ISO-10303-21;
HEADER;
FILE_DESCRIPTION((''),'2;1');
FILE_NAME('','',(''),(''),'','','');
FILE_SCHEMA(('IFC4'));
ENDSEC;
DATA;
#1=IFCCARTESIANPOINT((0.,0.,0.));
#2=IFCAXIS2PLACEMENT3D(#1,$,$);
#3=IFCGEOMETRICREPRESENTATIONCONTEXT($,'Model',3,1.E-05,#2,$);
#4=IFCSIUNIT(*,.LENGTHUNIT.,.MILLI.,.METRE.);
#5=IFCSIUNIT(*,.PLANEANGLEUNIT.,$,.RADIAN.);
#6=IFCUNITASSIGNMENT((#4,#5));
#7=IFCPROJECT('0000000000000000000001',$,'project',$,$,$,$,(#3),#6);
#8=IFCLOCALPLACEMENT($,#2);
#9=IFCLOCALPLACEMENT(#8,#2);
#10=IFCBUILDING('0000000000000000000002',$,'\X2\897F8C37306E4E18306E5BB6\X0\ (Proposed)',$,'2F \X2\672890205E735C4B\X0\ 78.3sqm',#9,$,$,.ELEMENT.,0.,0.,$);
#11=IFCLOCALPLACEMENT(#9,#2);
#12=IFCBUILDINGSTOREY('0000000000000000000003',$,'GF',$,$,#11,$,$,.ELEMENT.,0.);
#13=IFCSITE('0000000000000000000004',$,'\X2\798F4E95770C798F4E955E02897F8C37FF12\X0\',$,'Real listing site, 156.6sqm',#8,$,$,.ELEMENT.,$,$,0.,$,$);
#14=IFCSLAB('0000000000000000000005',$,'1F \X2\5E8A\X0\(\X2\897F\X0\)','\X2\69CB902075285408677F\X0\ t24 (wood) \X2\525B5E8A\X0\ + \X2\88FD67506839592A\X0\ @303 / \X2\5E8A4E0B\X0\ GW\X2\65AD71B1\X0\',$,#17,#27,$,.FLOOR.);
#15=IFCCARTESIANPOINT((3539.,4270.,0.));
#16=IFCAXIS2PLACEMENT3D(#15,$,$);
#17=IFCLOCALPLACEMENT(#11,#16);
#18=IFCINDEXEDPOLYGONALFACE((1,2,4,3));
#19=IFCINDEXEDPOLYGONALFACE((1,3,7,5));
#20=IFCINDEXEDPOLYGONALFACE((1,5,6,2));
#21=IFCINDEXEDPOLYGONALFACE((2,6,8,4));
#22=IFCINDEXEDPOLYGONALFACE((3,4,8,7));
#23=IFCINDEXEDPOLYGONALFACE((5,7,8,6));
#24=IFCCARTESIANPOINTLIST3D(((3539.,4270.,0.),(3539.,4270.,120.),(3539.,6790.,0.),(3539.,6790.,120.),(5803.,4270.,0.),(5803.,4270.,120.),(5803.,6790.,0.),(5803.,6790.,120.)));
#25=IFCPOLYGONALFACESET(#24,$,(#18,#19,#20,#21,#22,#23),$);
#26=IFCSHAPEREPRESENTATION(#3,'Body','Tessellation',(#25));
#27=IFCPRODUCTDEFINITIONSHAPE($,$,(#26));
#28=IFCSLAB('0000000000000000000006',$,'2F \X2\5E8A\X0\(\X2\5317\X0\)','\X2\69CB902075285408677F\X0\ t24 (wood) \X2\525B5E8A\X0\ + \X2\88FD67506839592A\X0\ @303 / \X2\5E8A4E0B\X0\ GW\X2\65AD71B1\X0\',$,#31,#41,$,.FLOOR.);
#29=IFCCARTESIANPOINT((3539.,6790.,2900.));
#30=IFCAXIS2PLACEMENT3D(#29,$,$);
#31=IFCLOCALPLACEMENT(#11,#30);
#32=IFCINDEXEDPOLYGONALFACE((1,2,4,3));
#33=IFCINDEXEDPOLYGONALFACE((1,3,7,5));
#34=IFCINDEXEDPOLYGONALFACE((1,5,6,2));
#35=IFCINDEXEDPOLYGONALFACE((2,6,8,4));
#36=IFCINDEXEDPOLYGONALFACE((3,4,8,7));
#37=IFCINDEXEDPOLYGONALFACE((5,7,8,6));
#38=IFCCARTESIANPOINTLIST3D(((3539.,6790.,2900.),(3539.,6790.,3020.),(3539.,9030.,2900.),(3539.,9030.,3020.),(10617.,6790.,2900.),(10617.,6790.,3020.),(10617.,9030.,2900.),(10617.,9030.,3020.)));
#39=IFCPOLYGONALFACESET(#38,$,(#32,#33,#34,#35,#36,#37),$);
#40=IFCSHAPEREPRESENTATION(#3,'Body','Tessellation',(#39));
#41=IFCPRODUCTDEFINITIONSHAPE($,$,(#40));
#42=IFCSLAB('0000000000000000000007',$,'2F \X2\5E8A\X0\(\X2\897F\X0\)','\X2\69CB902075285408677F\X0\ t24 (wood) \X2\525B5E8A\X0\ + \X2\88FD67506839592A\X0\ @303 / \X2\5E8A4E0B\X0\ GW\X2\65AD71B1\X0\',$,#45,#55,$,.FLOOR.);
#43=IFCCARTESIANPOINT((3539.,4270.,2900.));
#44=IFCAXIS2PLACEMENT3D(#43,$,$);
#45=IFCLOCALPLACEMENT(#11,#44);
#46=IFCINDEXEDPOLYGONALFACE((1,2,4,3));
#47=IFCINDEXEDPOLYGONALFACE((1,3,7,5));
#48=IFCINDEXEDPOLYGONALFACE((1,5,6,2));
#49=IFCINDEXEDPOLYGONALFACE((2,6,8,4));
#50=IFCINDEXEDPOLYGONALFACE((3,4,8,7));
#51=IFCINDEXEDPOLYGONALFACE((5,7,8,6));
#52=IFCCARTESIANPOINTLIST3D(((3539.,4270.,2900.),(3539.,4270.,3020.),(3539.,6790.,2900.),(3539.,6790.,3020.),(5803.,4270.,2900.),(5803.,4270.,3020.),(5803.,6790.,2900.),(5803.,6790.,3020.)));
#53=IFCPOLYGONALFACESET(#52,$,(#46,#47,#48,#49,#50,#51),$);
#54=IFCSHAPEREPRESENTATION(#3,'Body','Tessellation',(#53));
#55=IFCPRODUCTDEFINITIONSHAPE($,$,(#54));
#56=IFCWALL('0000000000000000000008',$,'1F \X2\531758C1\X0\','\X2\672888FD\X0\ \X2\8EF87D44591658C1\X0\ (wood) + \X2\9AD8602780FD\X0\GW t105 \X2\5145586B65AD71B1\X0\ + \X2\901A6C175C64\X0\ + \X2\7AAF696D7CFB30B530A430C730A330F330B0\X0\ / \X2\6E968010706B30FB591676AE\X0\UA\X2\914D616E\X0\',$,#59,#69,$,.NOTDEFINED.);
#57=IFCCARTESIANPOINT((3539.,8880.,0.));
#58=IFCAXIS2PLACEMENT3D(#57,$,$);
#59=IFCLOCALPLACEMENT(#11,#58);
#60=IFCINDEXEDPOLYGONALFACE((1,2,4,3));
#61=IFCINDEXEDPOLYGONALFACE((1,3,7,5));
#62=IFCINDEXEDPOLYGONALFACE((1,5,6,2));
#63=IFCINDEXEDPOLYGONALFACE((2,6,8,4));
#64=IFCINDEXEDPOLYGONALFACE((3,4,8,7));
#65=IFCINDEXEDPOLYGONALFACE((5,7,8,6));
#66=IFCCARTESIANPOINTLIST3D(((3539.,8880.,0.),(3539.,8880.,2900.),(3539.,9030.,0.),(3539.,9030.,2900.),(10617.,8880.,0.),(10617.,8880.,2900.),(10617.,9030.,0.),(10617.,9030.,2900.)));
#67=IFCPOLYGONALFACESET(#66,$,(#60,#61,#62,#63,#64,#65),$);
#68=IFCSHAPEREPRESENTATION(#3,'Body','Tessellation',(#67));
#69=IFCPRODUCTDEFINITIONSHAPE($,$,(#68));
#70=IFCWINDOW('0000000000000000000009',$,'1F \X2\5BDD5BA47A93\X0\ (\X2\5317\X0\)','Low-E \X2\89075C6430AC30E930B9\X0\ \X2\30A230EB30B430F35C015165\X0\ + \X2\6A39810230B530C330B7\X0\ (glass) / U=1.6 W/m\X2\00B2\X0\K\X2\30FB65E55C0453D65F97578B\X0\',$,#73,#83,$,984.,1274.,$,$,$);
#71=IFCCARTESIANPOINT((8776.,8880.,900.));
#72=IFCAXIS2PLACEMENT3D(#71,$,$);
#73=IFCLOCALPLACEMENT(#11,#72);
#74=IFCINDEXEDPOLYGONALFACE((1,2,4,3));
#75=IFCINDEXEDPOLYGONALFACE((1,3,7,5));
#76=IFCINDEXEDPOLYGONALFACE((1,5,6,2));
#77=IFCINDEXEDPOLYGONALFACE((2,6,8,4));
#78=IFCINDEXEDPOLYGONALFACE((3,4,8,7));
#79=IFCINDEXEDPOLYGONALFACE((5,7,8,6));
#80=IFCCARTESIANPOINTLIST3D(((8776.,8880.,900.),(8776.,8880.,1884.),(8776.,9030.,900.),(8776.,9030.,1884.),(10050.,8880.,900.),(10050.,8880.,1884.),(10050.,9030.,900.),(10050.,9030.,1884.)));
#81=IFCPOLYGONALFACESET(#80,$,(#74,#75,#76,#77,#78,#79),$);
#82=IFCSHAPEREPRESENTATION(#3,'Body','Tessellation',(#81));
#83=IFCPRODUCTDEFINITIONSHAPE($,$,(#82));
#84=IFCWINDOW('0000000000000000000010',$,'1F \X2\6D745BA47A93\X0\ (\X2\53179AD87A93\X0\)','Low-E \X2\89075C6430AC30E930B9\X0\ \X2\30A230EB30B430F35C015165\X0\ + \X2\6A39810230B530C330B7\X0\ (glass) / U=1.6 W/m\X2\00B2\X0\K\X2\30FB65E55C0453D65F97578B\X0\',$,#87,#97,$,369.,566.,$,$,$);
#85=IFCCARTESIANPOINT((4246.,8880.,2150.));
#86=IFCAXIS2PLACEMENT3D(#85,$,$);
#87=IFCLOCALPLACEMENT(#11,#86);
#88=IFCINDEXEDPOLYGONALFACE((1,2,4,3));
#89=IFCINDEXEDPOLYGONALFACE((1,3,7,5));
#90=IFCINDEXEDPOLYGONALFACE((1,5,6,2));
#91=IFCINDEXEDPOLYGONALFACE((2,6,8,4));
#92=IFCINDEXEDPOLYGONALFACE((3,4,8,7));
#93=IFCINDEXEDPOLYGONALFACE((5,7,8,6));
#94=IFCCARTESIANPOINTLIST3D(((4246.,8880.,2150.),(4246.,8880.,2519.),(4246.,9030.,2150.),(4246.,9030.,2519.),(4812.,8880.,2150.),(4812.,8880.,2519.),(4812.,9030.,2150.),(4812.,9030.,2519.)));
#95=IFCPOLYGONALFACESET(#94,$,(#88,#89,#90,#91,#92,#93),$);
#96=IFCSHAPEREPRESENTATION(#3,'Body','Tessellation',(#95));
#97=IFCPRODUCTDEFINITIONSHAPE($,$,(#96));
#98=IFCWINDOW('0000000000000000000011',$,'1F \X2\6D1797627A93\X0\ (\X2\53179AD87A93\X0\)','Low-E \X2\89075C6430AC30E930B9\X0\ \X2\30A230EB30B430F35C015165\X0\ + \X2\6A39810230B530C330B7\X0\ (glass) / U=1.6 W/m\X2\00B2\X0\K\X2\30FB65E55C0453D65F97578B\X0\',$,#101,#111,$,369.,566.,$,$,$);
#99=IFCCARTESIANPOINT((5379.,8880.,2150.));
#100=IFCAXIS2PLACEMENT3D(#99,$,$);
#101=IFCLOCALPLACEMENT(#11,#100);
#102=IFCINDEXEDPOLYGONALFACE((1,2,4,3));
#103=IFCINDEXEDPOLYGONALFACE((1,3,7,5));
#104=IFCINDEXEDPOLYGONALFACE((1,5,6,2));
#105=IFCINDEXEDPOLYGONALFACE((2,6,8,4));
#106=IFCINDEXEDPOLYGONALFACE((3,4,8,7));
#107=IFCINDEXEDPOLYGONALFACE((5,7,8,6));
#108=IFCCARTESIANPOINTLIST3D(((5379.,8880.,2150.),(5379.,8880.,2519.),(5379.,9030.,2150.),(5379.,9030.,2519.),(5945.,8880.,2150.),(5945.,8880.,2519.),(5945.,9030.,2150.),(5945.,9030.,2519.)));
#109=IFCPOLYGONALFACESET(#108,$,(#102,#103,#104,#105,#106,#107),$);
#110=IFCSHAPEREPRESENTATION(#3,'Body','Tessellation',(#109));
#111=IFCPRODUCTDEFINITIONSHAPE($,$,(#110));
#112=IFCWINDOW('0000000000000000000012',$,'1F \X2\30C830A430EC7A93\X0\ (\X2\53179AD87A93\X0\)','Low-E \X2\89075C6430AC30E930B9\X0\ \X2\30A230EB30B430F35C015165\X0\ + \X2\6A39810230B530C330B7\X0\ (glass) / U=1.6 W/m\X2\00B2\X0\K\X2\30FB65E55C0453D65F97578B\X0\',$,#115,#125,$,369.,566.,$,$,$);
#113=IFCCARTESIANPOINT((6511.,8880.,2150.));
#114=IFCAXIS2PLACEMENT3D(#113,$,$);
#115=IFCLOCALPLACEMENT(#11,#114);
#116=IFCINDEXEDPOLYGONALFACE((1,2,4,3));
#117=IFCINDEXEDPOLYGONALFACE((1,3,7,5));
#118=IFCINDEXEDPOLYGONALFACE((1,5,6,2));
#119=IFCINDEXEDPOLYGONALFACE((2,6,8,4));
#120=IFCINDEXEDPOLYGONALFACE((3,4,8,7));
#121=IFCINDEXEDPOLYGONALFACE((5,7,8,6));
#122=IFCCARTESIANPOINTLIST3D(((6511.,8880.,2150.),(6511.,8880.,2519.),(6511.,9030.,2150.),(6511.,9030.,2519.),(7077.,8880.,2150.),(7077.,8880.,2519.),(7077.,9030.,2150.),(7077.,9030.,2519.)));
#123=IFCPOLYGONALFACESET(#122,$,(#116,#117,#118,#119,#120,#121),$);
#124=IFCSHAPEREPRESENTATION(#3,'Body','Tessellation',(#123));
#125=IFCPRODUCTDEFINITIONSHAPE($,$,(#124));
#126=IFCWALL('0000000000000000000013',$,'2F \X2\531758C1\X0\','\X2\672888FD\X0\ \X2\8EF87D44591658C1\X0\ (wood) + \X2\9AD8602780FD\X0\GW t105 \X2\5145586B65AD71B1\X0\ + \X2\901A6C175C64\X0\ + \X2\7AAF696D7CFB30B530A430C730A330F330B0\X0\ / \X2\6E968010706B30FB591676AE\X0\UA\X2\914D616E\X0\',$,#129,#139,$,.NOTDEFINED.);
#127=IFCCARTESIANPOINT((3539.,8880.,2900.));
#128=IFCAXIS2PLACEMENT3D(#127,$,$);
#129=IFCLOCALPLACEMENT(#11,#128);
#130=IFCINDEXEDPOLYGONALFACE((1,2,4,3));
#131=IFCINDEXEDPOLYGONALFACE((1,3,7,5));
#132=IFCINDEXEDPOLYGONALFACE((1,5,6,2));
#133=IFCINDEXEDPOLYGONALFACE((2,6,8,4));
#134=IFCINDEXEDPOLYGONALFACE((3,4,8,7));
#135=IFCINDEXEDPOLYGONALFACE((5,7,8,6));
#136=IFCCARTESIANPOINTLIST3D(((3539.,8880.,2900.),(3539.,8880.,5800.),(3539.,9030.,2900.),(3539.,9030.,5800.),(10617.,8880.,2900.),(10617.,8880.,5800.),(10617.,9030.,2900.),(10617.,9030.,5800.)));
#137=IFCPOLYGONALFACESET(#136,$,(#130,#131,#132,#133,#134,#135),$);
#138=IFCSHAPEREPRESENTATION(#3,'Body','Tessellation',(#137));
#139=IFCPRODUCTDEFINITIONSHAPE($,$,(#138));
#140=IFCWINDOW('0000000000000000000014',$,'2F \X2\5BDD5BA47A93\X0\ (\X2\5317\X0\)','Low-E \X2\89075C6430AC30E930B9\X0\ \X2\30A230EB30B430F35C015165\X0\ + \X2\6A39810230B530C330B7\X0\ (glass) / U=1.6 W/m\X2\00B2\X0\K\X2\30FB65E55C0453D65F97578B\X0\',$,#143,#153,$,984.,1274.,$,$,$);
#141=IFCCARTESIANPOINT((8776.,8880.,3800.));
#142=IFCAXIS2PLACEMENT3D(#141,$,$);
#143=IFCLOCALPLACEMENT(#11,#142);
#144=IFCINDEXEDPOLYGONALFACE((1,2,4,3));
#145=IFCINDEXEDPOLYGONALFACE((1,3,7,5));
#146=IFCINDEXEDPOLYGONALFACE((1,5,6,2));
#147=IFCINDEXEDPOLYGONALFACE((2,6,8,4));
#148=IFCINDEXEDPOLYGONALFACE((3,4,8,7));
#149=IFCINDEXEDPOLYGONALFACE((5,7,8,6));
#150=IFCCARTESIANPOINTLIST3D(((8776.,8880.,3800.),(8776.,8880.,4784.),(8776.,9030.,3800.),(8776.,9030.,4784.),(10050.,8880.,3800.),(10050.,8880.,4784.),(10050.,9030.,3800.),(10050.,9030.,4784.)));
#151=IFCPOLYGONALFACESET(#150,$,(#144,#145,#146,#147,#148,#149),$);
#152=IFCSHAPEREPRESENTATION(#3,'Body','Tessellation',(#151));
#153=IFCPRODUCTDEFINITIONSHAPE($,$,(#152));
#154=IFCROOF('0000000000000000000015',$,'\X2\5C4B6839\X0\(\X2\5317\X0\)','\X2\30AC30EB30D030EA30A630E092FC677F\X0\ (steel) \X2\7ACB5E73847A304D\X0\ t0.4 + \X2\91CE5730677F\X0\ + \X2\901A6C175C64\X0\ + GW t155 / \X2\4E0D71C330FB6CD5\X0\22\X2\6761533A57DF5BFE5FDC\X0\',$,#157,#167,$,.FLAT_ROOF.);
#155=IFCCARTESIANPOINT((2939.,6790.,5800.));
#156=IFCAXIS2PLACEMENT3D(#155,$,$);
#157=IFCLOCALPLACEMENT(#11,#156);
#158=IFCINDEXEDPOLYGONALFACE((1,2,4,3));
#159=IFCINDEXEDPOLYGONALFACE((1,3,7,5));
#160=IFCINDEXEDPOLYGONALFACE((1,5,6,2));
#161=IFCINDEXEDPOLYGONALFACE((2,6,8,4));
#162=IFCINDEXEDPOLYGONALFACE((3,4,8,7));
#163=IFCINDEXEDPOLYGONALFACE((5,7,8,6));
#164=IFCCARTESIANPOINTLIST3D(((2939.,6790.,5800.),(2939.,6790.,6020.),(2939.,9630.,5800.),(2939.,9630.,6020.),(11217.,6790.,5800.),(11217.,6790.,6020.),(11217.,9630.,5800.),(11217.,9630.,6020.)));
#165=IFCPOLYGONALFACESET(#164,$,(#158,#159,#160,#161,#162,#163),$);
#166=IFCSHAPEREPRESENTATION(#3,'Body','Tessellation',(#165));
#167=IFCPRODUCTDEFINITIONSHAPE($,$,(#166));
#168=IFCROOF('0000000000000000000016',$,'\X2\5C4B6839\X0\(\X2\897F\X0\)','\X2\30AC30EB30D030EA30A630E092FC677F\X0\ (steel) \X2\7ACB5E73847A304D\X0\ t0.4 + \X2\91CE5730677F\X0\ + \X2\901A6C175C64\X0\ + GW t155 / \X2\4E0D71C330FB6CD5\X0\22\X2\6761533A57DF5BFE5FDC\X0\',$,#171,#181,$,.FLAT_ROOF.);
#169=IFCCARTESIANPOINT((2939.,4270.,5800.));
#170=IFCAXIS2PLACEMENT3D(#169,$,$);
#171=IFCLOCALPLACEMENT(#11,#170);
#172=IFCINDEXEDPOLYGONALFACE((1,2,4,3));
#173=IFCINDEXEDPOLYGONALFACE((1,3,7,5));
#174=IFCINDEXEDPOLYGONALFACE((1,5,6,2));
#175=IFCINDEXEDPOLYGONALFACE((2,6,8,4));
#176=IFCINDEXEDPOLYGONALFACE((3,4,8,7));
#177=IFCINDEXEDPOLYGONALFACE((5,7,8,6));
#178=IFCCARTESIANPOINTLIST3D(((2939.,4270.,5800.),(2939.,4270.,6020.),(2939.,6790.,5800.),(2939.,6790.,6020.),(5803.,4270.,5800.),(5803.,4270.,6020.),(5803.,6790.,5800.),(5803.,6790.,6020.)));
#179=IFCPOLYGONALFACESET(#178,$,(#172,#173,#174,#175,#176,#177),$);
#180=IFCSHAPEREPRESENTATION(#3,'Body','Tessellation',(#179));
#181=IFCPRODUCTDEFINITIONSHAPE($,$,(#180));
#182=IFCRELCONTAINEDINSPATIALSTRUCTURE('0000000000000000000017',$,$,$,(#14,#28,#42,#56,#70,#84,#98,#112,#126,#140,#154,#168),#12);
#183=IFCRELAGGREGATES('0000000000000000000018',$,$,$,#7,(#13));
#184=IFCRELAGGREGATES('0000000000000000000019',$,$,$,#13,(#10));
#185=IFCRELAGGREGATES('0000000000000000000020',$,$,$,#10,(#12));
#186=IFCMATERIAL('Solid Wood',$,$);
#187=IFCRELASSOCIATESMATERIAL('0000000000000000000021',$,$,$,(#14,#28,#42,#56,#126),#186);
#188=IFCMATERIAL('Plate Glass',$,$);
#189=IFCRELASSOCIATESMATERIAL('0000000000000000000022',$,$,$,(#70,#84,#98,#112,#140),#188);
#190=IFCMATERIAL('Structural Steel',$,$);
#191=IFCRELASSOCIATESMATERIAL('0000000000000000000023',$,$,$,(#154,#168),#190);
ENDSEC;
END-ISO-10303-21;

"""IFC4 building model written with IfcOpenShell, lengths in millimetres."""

from ifc_helpers import new_model, si_unit, frame, frame_2d, origin, place, context, project, spatial, rectangle, extrude, material, element, fill, save


model = new_model("IFC4")

# Units and contexts
model_context = context("Model", 3, precision=1e-05, world=origin())
ifc_project = project(units=[si_unit("LENGTHUNIT", "METRE", prefix="MILLI"), si_unit("PLANEANGLEUNIT", "RADIAN")], contexts=[model_context])

# Site, building, storey
site_placement = place(None, origin())
site = spatial("IfcSite", under=ifc_project, at=site_placement, Name="福井県福井市西谷２", ObjectType="Real listing site, 156.6sqm", CompositionType="ELEMENT", RefElevation=0.0)
building_placement = place(site_placement, origin())
building = spatial("IfcBuilding", under=site, at=building_placement, Name="西谷の丘の家 (Proposed)", ObjectType="2F 木造平屋 78.3sqm", CompositionType="ELEMENT", ElevationOfRefHeight=0.0, ElevationOfTerrain=0.0)
storey_placement = place(building_placement, origin())
storey = spatial("IfcBuildingStorey", under=building, at=storey_placement, Name="GF", CompositionType="ELEMENT", Elevation=0.0)

# Slabs
ifc_material_1 = material(Name="Solid Wood")
slab_1_placement = place(storey_placement, frame((3539.0, 4270.0, 0.0)))
element("IfcSlab", 1, at=slab_1_placement, inside=storey, material=ifc_material_1, Name="1F 床(西)", Description="構造用合板 t24 (wood) 剛床 + 製材根太 @303 / 床下 GW断熱", PredefinedType="FLOOR", context=model_context, shape_type="SweptSolid", body=[
    extrude(rectangle(XDim=2264.0, YDim=2520.0, at=frame_2d((1132.0, 1260.0))), frame((3539.0, 4270.0, 0.0)), (0.0, 0.0, 1.0), 120.0),
])
slab_2_placement = place(storey_placement, frame((3539.0, 6790.0, 2900.0)))
element("IfcSlab", 2, at=slab_2_placement, inside=storey, material=ifc_material_1, Name="2F 床(北)", Description="構造用合板 t24 (wood) 剛床 + 製材根太 @303 / 床下 GW断熱", PredefinedType="FLOOR", context=model_context, shape_type="SweptSolid", body=[
    extrude(rectangle(XDim=7078.0, YDim=2240.0, at=frame_2d((3539.0, 1120.0))), frame((3539.0, 6790.0, 2900.0)), (0.0, 0.0, 1.0), 120.0),
])
slab_3_placement = place(storey_placement, frame((3539.0, 4270.0, 2900.0)))
element("IfcSlab", 3, at=slab_3_placement, inside=storey, material=ifc_material_1, Name="2F 床(西)", Description="構造用合板 t24 (wood) 剛床 + 製材根太 @303 / 床下 GW断熱", PredefinedType="FLOOR", context=model_context, shape_type="SweptSolid", body=[
    extrude(rectangle(XDim=2264.0, YDim=2520.0, at=frame_2d((1132.0, 1260.0))), frame((3539.0, 4270.0, 2900.0)), (0.0, 0.0, 1.0), 120.0),
])

# Wall, openings, windows
wall_1_placement = place(storey_placement, frame((3539.0, 8880.0, 0.0)))
wall_1 = element("IfcWall", 4, at=wall_1_placement, inside=storey, material=ifc_material_1, Name="1F 北壁", Description="木製 軸組外壁 (wood) + 高性能GW t105 充填断熱 + 通気層 + 窯業系サイディング / 準耐火・外皮UA配慮", PredefinedType="NOTDEFINED", context=model_context, shape_type="SweptSolid", body=[
    extrude(rectangle(XDim=7078.0, YDim=150.0, at=frame_2d((3539.0, 75.0))), frame((3539.0, 8880.0, 0.0)), (0.0, 0.0, 1.0), 2900.0),
])
opening_1_placement = place(storey_placement, frame((8776.0, 8880.0, 900.0)))
opening_1 = element("IfcOpeningElement", 5, at=opening_1_placement, cuts=wall_1, PredefinedType="NOTDEFINED", context=model_context, shape_type="SweptSolid", body=[
    extrude(rectangle(XDim=1274.0, YDim=150.0, at=frame_2d((637.0, 75.0))), frame((8776.0, 8880.0, 900.0)), (0.0, 0.0, 1.0), 984.0),
])
opening_2_placement = place(storey_placement, frame((4246.0, 8880.0, 2150.0)))
opening_2 = element("IfcOpeningElement", 6, at=opening_2_placement, cuts=wall_1, PredefinedType="NOTDEFINED", context=model_context, shape_type="SweptSolid", body=[
    extrude(rectangle(XDim=566.0, YDim=150.0, at=frame_2d((283.0, 75.0))), frame((4246.0, 8880.0, 2150.0)), (0.0, 0.0, 1.0), 369.0),
])
opening_3_placement = place(storey_placement, frame((5379.0, 8880.0, 2150.0)))
opening_3 = element("IfcOpeningElement", 7, at=opening_3_placement, cuts=wall_1, PredefinedType="NOTDEFINED", context=model_context, shape_type="SweptSolid", body=[
    extrude(rectangle(XDim=566.0, YDim=150.0, at=frame_2d((283.0, 75.0))), frame((5379.0, 8880.0, 2150.0)), (0.0, 0.0, 1.0), 369.0),
])
opening_4_placement = place(storey_placement, frame((6511.0, 8880.0, 2150.0)))
opening_4 = element("IfcOpeningElement", 8, at=opening_4_placement, cuts=wall_1, PredefinedType="NOTDEFINED", context=model_context, shape_type="SweptSolid", body=[
    extrude(rectangle(XDim=566.0, YDim=150.0, at=frame_2d((283.0, 75.0))), frame((6511.0, 8880.0, 2150.0)), (0.0, 0.0, 1.0), 369.0),
])
ifc_material_2 = material(Name="Plate Glass")
window_1_placement = place(storey_placement, frame((8776.0, 8880.0, 900.0)))
window_1 = element("IfcWindow", 9, at=window_1_placement, inside=storey, material=ifc_material_2, Name="1F 寝室窓 (北)", Description="Low-E 複層ガラス アルゴン封入 + 樹脂サッシ (glass) / U=1.6 W/m²K・日射取得型", OverallHeight=984.0, OverallWidth=1274.0, context=model_context, shape_type="SweptSolid", body=[
    extrude(rectangle(XDim=1274.0, YDim=150.0, at=frame_2d((637.0, 75.0))), frame((8776.0, 8880.0, 900.0)), (0.0, 0.0, 1.0), 984.0),
])
fill(opening_1, window_1)
window_2_placement = place(storey_placement, frame((4246.0, 8880.0, 2150.0)))
window_2 = element("IfcWindow", 10, at=window_2_placement, inside=storey, material=ifc_material_2, Name="1F 浴室窓 (北高窓)", Description="Low-E 複層ガラス アルゴン封入 + 樹脂サッシ (glass) / U=1.6 W/m²K・日射取得型", OverallHeight=369.0, OverallWidth=566.0, context=model_context, shape_type="SweptSolid", body=[
    extrude(rectangle(XDim=566.0, YDim=150.0, at=frame_2d((283.0, 75.0))), frame((4246.0, 8880.0, 2150.0)), (0.0, 0.0, 1.0), 369.0),
])
fill(opening_2, window_2)
window_3_placement = place(storey_placement, frame((5379.0, 8880.0, 2150.0)))
window_3 = element("IfcWindow", 11, at=window_3_placement, inside=storey, material=ifc_material_2, Name="1F 洗面窓 (北高窓)", Description="Low-E 複層ガラス アルゴン封入 + 樹脂サッシ (glass) / U=1.6 W/m²K・日射取得型", OverallHeight=369.0, OverallWidth=566.0, context=model_context, shape_type="SweptSolid", body=[
    extrude(rectangle(XDim=566.0, YDim=150.0, at=frame_2d((283.0, 75.0))), frame((5379.0, 8880.0, 2150.0)), (0.0, 0.0, 1.0), 369.0),
])
fill(opening_3, window_3)
window_4_placement = place(storey_placement, frame((6511.0, 8880.0, 2150.0)))
window_4 = element("IfcWindow", 12, at=window_4_placement, inside=storey, material=ifc_material_2, Name="1F トイレ窓 (北高窓)", Description="Low-E 複層ガラス アルゴン封入 + 樹脂サッシ (glass) / U=1.6 W/m²K・日射取得型", OverallHeight=369.0, OverallWidth=566.0, context=model_context, shape_type="SweptSolid", body=[
    extrude(rectangle(XDim=566.0, YDim=150.0, at=frame_2d((283.0, 75.0))), frame((6511.0, 8880.0, 2150.0)), (0.0, 0.0, 1.0), 369.0),
])
fill(opening_4, window_4)

# Wall, opening, window
wall_2_placement = place(storey_placement, frame((3539.0, 8880.0, 2900.0)))
wall_2 = element("IfcWall", 13, at=wall_2_placement, inside=storey, material=ifc_material_1, Name="2F 北壁", Description="木製 軸組外壁 (wood) + 高性能GW t105 充填断熱 + 通気層 + 窯業系サイディング / 準耐火・外皮UA配慮", PredefinedType="NOTDEFINED", context=model_context, shape_type="SweptSolid", body=[
    extrude(rectangle(XDim=7078.0, YDim=150.0, at=frame_2d((3539.0, 75.0))), frame((3539.0, 8880.0, 2900.0)), (0.0, 0.0, 1.0), 2900.0),
])
opening_5_placement = place(storey_placement, frame((8776.0, 8880.0, 3800.0)))
opening_5 = element("IfcOpeningElement", 14, at=opening_5_placement, cuts=wall_2, PredefinedType="NOTDEFINED", context=model_context, shape_type="SweptSolid", body=[
    extrude(rectangle(XDim=1274.0, YDim=150.0, at=frame_2d((637.0, 75.0))), frame((8776.0, 8880.0, 3800.0)), (0.0, 0.0, 1.0), 984.0),
])
window_5_placement = place(storey_placement, frame((8776.0, 8880.0, 3800.0)))
window_5 = element("IfcWindow", 15, at=window_5_placement, inside=storey, material=ifc_material_2, Name="2F 寝室窓 (北)", Description="Low-E 複層ガラス アルゴン封入 + 樹脂サッシ (glass) / U=1.6 W/m²K・日射取得型", OverallHeight=984.0, OverallWidth=1274.0, context=model_context, shape_type="SweptSolid", body=[
    extrude(rectangle(XDim=1274.0, YDim=150.0, at=frame_2d((637.0, 75.0))), frame((8776.0, 8880.0, 3800.0)), (0.0, 0.0, 1.0), 984.0),
])
fill(opening_5, window_5)

# Roofs
ifc_material_3 = material(Name="Structural Steel")
for number, where, name in (
    (16, (2939.0, 6790.0, 5800.0), "屋根(北)"),
):
    element("IfcRoof", number, at=place(storey_placement, frame(where)), inside=storey, material=ifc_material_3, Name=name, Description="ガルバリウム鋼板 (steel) 立平葺き t0.4 + 野地板 + 通気層 + GW t155 / 不燃・法22条区域対応", PredefinedType="FLAT_ROOF", context=model_context, shape_type="SweptSolid", body=[
        extrude(rectangle(XDim=8278.0, YDim=2840.0, at=frame_2d((4139.0, 1420.0))), frame((2939.0, 6790.0, 5800.0)), (0.0, 0.0, 1.0), 220.0),
    ])
roof_placement = place(storey_placement, frame((2939.0, 4270.0, 5800.0)))
element("IfcRoof", 17, at=roof_placement, inside=storey, material=ifc_material_3, Name="屋根(西)", Description="ガルバリウム鋼板 (steel) 立平葺き t0.4 + 野地板 + 通気層 + GW t155 / 不燃・法22条区域対応", PredefinedType="FLAT_ROOF", context=model_context, shape_type="SweptSolid", body=[
    extrude(rectangle(XDim=2864.0, YDim=2520.0, at=frame_2d((1432.0, 1260.0))), frame((2939.0, 4270.0, 5800.0)), (0.0, 0.0, 1.0), 220.0),
])

save(model, "model.ifc")
